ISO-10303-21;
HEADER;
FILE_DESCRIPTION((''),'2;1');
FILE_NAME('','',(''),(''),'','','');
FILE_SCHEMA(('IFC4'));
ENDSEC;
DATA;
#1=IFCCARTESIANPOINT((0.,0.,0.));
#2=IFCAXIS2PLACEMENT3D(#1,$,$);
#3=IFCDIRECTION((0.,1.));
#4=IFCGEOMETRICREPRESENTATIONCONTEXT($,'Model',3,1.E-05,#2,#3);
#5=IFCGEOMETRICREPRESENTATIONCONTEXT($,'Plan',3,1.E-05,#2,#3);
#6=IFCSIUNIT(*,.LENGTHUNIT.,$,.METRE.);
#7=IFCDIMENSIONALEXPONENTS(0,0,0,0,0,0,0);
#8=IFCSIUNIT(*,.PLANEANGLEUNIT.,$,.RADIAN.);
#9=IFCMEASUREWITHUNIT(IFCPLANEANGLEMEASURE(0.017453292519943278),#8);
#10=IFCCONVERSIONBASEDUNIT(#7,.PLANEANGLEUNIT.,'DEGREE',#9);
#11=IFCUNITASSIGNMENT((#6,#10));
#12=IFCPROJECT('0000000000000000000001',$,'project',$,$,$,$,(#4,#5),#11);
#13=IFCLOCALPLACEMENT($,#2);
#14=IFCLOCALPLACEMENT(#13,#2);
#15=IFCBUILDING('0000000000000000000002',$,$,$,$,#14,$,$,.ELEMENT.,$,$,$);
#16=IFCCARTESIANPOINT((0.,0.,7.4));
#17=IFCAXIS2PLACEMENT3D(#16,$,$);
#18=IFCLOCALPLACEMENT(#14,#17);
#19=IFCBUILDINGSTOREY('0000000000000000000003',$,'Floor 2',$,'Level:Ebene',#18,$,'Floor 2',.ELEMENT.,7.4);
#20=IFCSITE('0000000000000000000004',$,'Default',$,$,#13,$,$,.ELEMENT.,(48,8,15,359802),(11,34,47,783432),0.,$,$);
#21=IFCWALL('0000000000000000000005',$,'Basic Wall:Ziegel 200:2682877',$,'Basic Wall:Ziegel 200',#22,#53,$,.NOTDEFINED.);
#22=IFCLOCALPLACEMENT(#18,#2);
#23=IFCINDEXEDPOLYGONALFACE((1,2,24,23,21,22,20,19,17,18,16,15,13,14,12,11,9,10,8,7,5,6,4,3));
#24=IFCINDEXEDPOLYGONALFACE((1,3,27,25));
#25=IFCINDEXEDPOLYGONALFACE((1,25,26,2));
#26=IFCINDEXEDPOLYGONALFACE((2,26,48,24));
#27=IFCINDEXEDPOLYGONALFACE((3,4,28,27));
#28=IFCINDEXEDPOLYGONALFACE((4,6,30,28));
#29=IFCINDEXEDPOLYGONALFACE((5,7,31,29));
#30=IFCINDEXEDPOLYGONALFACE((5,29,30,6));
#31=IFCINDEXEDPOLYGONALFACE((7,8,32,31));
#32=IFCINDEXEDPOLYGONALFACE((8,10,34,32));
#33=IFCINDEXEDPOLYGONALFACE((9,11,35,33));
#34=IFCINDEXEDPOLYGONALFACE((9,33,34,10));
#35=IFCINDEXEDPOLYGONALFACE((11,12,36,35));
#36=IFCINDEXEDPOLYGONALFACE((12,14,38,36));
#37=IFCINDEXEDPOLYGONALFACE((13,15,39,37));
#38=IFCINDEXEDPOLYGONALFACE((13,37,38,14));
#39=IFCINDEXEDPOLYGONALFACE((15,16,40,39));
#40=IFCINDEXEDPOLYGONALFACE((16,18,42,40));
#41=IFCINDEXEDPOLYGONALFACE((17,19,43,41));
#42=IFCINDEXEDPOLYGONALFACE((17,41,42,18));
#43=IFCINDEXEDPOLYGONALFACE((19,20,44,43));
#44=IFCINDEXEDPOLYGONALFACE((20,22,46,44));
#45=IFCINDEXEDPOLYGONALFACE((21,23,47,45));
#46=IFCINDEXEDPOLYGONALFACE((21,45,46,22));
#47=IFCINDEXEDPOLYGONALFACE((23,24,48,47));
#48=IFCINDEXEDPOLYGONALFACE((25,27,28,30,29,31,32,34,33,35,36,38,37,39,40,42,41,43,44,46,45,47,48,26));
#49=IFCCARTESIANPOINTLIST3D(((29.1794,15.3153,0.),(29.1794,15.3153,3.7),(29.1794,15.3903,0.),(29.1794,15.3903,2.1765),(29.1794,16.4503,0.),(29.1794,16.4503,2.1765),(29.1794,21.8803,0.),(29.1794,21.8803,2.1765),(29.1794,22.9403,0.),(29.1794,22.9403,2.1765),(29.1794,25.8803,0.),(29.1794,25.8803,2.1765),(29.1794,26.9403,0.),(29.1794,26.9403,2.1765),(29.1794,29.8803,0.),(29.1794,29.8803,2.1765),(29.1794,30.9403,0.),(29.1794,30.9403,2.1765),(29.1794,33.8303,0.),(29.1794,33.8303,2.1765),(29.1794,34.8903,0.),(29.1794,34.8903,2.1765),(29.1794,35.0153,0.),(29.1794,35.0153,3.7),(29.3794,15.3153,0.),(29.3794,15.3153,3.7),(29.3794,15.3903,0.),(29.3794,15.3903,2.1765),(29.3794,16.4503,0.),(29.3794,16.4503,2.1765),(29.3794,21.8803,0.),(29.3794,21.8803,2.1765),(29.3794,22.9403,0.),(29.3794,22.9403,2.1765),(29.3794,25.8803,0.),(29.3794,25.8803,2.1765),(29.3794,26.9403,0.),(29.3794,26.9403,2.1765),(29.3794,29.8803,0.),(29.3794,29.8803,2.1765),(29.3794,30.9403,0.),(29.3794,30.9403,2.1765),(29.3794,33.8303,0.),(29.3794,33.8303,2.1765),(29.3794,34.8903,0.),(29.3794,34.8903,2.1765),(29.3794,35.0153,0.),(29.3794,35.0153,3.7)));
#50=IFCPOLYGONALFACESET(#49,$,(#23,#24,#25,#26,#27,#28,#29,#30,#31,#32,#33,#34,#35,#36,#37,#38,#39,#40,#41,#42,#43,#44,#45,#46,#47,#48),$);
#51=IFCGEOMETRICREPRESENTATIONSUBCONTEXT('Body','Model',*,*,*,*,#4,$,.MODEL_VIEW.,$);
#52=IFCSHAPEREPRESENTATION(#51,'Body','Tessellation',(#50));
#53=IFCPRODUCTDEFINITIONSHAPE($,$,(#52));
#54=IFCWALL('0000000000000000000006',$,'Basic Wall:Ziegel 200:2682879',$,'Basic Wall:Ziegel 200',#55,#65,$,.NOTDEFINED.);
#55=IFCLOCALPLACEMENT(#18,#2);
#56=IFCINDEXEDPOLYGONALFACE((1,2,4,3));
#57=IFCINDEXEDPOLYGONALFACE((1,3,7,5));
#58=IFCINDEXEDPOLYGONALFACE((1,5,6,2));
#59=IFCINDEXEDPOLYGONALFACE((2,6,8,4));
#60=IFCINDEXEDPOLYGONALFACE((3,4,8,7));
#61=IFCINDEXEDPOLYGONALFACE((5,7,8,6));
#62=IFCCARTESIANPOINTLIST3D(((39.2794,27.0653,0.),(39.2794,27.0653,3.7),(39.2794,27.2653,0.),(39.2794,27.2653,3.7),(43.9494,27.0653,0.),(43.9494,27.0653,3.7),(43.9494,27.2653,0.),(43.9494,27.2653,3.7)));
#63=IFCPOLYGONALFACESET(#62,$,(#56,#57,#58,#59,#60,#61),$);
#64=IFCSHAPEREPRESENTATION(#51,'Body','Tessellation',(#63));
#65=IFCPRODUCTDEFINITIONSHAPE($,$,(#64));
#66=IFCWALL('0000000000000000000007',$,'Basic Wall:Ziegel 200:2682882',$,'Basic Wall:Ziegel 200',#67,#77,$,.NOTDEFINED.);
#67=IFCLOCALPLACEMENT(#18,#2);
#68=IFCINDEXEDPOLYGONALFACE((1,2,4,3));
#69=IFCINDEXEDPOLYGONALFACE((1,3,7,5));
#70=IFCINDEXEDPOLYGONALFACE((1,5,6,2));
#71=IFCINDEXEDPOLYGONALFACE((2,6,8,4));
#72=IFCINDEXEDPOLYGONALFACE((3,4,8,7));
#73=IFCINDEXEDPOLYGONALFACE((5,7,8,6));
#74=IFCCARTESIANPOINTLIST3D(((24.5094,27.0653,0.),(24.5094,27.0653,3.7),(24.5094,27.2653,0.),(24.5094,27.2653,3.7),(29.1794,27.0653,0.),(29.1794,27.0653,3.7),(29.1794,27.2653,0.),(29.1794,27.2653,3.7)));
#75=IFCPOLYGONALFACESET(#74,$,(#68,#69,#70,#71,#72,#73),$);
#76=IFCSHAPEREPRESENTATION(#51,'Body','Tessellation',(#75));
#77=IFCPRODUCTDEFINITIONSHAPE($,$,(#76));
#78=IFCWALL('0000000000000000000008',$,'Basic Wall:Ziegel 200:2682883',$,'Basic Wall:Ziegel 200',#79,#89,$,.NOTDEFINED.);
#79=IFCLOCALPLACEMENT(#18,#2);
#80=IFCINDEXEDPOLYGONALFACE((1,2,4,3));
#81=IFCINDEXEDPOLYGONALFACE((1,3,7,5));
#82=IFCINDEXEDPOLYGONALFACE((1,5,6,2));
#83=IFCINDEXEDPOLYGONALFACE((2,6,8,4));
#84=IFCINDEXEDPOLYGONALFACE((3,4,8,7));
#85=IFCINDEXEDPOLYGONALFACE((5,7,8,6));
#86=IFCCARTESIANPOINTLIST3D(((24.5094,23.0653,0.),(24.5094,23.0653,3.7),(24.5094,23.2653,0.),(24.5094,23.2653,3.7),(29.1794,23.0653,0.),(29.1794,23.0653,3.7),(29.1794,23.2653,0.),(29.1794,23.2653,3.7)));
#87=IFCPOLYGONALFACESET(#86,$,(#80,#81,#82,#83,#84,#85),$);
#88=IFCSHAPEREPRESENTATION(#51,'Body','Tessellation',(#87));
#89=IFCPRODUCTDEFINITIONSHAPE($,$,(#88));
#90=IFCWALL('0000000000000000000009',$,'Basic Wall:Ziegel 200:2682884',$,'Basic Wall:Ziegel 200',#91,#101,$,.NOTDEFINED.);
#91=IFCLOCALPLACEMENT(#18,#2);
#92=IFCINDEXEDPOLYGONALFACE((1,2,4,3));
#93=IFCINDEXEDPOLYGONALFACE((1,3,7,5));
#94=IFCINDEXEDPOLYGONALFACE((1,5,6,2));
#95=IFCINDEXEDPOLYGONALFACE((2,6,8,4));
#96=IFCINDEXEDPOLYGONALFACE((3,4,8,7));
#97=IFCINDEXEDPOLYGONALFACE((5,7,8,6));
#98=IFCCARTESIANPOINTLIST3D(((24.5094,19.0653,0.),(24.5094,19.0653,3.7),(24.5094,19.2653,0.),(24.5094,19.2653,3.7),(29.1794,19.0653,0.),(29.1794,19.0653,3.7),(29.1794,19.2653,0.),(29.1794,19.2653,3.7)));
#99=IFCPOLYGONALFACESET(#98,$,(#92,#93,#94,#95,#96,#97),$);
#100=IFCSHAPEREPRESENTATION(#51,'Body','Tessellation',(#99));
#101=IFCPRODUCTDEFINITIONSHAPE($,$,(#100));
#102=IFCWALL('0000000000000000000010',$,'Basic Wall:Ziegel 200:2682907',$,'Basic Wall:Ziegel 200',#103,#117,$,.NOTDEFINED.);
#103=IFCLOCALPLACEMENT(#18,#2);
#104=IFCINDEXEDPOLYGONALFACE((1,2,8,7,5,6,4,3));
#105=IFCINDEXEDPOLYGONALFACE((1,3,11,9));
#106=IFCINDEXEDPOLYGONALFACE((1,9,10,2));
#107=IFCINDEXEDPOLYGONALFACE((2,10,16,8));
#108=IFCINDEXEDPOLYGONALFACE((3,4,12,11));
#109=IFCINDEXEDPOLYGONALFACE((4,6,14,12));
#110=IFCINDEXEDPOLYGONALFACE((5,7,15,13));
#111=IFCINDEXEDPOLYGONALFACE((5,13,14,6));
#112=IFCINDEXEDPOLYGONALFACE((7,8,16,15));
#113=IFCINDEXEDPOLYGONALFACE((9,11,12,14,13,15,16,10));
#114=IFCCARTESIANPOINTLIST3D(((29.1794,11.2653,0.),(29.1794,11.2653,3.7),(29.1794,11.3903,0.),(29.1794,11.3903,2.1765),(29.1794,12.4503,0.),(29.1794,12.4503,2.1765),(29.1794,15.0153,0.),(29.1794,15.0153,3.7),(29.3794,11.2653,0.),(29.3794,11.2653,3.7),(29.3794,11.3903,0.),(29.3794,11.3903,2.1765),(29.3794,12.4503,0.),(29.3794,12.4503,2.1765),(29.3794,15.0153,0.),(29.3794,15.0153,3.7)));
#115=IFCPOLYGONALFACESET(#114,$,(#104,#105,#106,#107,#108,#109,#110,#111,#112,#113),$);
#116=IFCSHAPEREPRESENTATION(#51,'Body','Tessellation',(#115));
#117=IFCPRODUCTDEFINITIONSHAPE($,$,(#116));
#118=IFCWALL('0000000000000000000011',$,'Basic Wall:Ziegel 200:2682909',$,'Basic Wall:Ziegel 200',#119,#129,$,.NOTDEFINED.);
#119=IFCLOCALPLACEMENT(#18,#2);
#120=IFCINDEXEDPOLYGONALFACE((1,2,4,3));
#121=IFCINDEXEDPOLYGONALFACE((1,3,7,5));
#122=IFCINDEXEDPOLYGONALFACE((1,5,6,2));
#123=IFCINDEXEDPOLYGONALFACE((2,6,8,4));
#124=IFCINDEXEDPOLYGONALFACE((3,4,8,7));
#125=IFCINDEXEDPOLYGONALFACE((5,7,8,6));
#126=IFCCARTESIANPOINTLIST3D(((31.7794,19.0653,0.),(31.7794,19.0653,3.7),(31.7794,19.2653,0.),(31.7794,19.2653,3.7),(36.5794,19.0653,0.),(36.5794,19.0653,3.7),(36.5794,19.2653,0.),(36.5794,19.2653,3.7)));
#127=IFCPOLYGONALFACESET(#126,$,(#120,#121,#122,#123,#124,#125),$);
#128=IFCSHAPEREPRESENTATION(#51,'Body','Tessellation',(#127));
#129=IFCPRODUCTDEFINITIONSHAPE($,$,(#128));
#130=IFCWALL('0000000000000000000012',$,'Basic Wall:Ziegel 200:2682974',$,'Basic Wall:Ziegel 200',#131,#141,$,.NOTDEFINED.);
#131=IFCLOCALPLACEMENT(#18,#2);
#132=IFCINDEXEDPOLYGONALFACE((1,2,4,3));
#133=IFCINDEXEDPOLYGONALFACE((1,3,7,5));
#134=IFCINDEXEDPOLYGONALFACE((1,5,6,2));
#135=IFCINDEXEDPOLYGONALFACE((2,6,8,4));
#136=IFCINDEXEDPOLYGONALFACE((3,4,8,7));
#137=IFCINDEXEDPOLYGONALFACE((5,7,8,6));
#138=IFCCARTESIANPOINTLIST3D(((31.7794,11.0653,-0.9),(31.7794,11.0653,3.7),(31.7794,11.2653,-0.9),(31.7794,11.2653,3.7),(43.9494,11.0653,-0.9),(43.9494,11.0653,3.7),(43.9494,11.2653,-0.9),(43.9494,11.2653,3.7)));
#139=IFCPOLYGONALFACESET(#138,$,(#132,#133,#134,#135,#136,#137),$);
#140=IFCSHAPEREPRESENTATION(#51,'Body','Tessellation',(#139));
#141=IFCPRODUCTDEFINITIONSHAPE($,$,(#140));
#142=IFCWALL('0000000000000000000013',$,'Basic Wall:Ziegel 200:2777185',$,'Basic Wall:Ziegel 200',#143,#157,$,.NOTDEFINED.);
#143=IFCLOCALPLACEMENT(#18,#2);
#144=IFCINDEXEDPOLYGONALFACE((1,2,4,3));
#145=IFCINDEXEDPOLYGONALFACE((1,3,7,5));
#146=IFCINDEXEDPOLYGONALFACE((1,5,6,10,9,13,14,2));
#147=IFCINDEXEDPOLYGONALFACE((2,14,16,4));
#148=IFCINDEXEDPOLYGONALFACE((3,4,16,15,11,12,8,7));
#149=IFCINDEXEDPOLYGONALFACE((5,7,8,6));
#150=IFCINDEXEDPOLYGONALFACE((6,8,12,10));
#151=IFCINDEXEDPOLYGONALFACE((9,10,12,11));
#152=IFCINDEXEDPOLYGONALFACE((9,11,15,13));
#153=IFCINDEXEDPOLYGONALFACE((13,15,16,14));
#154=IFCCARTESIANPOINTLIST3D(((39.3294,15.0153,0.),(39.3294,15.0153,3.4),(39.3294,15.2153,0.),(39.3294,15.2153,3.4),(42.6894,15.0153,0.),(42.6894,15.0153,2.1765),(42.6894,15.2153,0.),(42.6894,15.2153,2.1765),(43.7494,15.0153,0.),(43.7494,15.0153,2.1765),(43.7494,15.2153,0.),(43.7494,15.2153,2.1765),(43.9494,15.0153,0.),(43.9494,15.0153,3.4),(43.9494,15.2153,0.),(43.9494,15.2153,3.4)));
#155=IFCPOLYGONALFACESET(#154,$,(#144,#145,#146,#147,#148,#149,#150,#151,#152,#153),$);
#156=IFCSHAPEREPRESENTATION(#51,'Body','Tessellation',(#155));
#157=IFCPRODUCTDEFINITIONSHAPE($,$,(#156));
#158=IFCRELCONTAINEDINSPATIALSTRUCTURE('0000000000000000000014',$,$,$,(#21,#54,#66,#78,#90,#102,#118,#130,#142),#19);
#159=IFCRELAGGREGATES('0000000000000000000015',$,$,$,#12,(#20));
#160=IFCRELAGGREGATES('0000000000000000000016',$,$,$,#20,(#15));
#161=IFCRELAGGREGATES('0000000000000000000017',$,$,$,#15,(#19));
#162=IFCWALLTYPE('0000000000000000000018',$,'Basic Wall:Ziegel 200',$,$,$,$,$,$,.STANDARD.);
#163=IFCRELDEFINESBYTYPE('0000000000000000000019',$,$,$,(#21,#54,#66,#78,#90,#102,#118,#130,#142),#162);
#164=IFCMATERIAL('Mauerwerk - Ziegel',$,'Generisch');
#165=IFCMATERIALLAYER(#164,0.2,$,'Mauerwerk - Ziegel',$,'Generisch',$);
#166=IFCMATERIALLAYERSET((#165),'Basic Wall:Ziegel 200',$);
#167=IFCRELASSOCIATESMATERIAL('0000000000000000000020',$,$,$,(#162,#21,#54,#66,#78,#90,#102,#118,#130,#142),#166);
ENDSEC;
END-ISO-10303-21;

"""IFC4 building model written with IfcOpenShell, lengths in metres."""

from ifc_helpers import new_model, entity, si_unit, converted_unit, direction, frame, frame_2d, origin, place, context, subcontext, project, spatial, polyline, rectangle, extrude, clip, bounded_halfspace, material, layer, layer_set, layer_usage, type_object, element, save


model = new_model("IFC4")

# Units and contexts
model_context = context("Model", 3, precision=1e-05, world=origin(), true_north=direction((0.0, 1.0)))
plan_context = context("Plan", 3, precision=1e-05, world=origin(), true_north=direction((0.0, 1.0)))
body_context = subcontext(model_context, "Body", "Model", "MODEL_VIEW")
ifc_project = project(units=[si_unit("LENGTHUNIT", "METRE"), converted_unit("PLANEANGLEUNIT", "DEGREE", entity("IfcPlaneAngleMeasure", 0.017453292519943278), si_unit("PLANEANGLEUNIT", "RADIAN"), dimensions=[0, 0, 0, 0, 0, 0, 0])], contexts=[model_context, plan_context])

# Site, building, storey
site_placement = place(None, origin())
site = spatial("IfcSite", under=ifc_project, at=site_placement, Name="Default", CompositionType="ELEMENT", RefLatitude=(48, 8, 15, 359802), RefLongitude=(11, 34, 47, 783432), RefElevation=0.0)
building_placement = place(site_placement, origin())
building = spatial("IfcBuilding", under=site, at=building_placement, CompositionType="ELEMENT")
storey_placement = place(building_placement, frame((0.0, 0.0, 7.4)))
storey = spatial("IfcBuildingStorey", under=building, at=storey_placement, Name="Floor 2", ObjectType="Level:Ebene", LongName="Floor 2", CompositionType="ELEMENT", Elevation=7.4)

# Shared definitions
ifc_material_1 = material(Name="Mauerwerk - Ziegel", Category="Generisch")
ifc_layer_1 = layer(ifc_material_1, 0.2, Name="Mauerwerk - Ziegel", Category="Generisch")
ifc_layer_set_1 = layer_set([ifc_layer_1], Name="Basic Wall:Ziegel 200")
ifc_layer_usage_1 = layer_usage(ifc_layer_set_1, "AXIS2", "NEGATIVE", 0.1)
wall_type_1 = type_object("IfcWallType", Name="Basic Wall:Ziegel 200", PredefinedType="STANDARD", material=ifc_layer_set_1)

# Wall, openings
wall_1_placement = place(storey_placement, frame((29.2794, 15.3153, 0.0), z_axis=(0.0, 0.0, 1.0), x_axis=(0.0, 1.0, 0.0)))
wall_1 = element("IfcWall", 1, at=wall_1_placement, inside=storey, type_object=wall_type_1, material=ifc_layer_usage_1, Name="Basic Wall:Ziegel 200:2682877", ObjectType="Basic Wall:Ziegel 200", PredefinedType="NOTDEFINED", context=body_context, shape_type="SweptSolid", body=[
    extrude(rectangle(XDim=19.7, YDim=0.2, at=frame_2d((9.85, 0.0), x_axis=(1.0, 0.0))), origin(), (0.0, 0.0, 1.0), 3.7),
])
opening_1_placement = place(wall_1_placement, frame((15.625, 0.1, 0.0)))
element("IfcOpeningElement", 2, at=opening_1_placement, cuts=wall_1, PredefinedType="OPENING", context=body_context, shape_type="SweptSolid", body=[
    extrude(rectangle(XDim=2.1765, YDim=1.06, at=frame_2d((1.0882, 0.53), x_axis=(1.0, 0.0))), frame((0.0, 0.0, 0.0), z_axis=(0.0, -1.0, 0.0), x_axis=(0.0, 0.0, 1.0)), (0.0, 0.0, 1.0), 0.2),
])
opening_2_placement = place(wall_1_placement, frame((11.625, 0.1, 0.0)))
element("IfcOpeningElement", 3, at=opening_2_placement, cuts=wall_1, PredefinedType="OPENING", context=body_context, shape_type="SweptSolid", body=[
    extrude(rectangle(XDim=2.1765, YDim=1.06, at=frame_2d((1.0882, 0.53), x_axis=(1.0, 0.0))), frame((0.0, 0.0, 0.0), z_axis=(0.0, -1.0, 0.0), x_axis=(0.0, 0.0, 1.0)), (0.0, 0.0, 1.0), 0.2),
])
opening_3_placement = place(wall_1_placement, frame((7.625, 0.1, 0.0)))
element("IfcOpeningElement", 4, at=opening_3_placement, cuts=wall_1, PredefinedType="OPENING", context=body_context, shape_type="SweptSolid", body=[
    extrude(rectangle(XDim=2.1765, YDim=1.06, at=frame_2d((1.0882, 0.53), x_axis=(1.0, 0.0))), frame((0.0, 0.0, 0.0), z_axis=(0.0, -1.0, 0.0), x_axis=(0.0, 0.0, 1.0)), (0.0, 0.0, 1.0), 0.2),
])
opening_4_placement = place(wall_1_placement, frame((1.135, 0.1, 0.0)))
element("IfcOpeningElement", 5, at=opening_4_placement, cuts=wall_1, PredefinedType="OPENING", context=body_context, shape_type="SweptSolid", body=[
    extrude(rectangle(XDim=2.1765, YDim=1.06, at=frame_2d((1.0882, 0.53), x_axis=(1.0, 0.0))), frame((0.0, 0.0, 0.0), z_axis=(0.0, -1.0, 0.0), x_axis=(0.0, 0.0, 1.0)), (0.0, 0.0, 1.0), 0.2),
])
opening_5_placement = place(wall_1_placement, frame((19.575, 0.1, 0.0)))
element("IfcOpeningElement", 6, at=opening_5_placement, cuts=wall_1, PredefinedType="OPENING", context=body_context, shape_type="SweptSolid", body=[
    extrude(rectangle(XDim=2.1765, YDim=1.06, at=frame_2d((1.0882, 0.53), x_axis=(1.0, 0.0))), frame((0.0, 0.0, 0.0), z_axis=(0.0, -1.0, 0.0), x_axis=(0.0, 0.0, 1.0)), (0.0, 0.0, 1.0), 0.2),
])

# Walls
wall_2_placement = place(storey_placement, frame((39.2794, 27.1653, 0.0)))
element("IfcWall", 7, at=wall_2_placement, inside=storey, type_object=wall_type_1, material=ifc_layer_usage_1, Name="Basic Wall:Ziegel 200:2682879", ObjectType="Basic Wall:Ziegel 200", PredefinedType="NOTDEFINED", context=body_context, shape_type="SweptSolid", body=[
    extrude(rectangle(XDim=4.67, YDim=0.2, at=frame_2d((2.335, 0.0), x_axis=(-1.0, 0.0))), origin(), (0.0, 0.0, 1.0), 3.7),
])
wall_3_placement = place(storey_placement, frame((29.1794, 27.1653, 0.0), z_axis=(0.0, 0.0, 1.0), x_axis=(-1.0, 0.0, 0.0)))
element("IfcWall", 8, at=wall_3_placement, inside=storey, type_object=wall_type_1, material=ifc_layer_usage_1, Name="Basic Wall:Ziegel 200:2682882", ObjectType="Basic Wall:Ziegel 200", PredefinedType="NOTDEFINED", context=body_context, shape_type="SweptSolid", body=[
    extrude(rectangle(XDim=4.67, YDim=0.2, at=frame_2d((2.335, 0.0), x_axis=(-1.0, 0.0))), origin(), (0.0, 0.0, 1.0), 3.7),
])
wall_4_placement = place(storey_placement, frame((29.1794, 23.1653, 0.0), z_axis=(0.0, 0.0, 1.0), x_axis=(-1.0, 0.0, 0.0)))
element("IfcWall", 9, at=wall_4_placement, inside=storey, type_object=wall_type_1, material=ifc_layer_usage_1, Name="Basic Wall:Ziegel 200:2682883", ObjectType="Basic Wall:Ziegel 200", PredefinedType="NOTDEFINED", context=body_context, shape_type="SweptSolid", body=[
    extrude(rectangle(XDim=4.67, YDim=0.2, at=frame_2d((2.335, 0.0), x_axis=(-1.0, 0.0))), origin(), (0.0, 0.0, 1.0), 3.7),
])
wall_5_placement = place(storey_placement, frame((29.1794, 19.1653, 0.0), z_axis=(0.0, 0.0, 1.0), x_axis=(-1.0, 0.0, 0.0)))
element("IfcWall", 10, at=wall_5_placement, inside=storey, type_object=wall_type_1, material=ifc_layer_usage_1, Name="Basic Wall:Ziegel 200:2682884", ObjectType="Basic Wall:Ziegel 200", PredefinedType="NOTDEFINED", context=body_context, shape_type="SweptSolid", body=[
    extrude(rectangle(XDim=4.67, YDim=0.2, at=frame_2d((2.335, 0.0), x_axis=(-1.0, 0.0))), origin(), (0.0, 0.0, 1.0), 3.7),
])

# Wall, opening
wall_6_placement = place(storey_placement, frame((29.2794, 15.0153, 0.0), z_axis=(0.0, 0.0, 1.0), x_axis=(0.0, -1.0, 0.0)))
wall_6 = element("IfcWall", 11, at=wall_6_placement, inside=storey, type_object=wall_type_1, material=ifc_layer_usage_1, Name="Basic Wall:Ziegel 200:2682907", ObjectType="Basic Wall:Ziegel 200", PredefinedType="NOTDEFINED", context=body_context, shape_type="SweptSolid", body=[
    extrude(rectangle(XDim=3.75, YDim=0.2, at=frame_2d((1.875, 0.0), x_axis=(-1.0, 0.0))), origin(), (0.0, 0.0, 1.0), 3.7),
])
opening_6_placement = place(wall_6_placement, frame((2.565, -0.1, 0.0)))
element("IfcOpeningElement", 12, at=opening_6_placement, cuts=wall_6, PredefinedType="OPENING", context=body_context, shape_type="SweptSolid", body=[
    extrude(rectangle(XDim=2.1765, YDim=1.06, at=frame_2d((1.0882, 0.53), x_axis=(1.0, 0.0))), frame((0.0, 0.0, 0.0), z_axis=(0.0, 1.0, 0.0), x_axis=(0.0, 0.0, 1.0)), (0.0, 0.0, 1.0), 0.2),
])

# Walls
wall_7_placement = place(storey_placement, frame((31.7794, 19.1653, 0.0)))
element("IfcWall", 13, at=wall_7_placement, inside=storey, type_object=wall_type_1, material=ifc_layer_usage_1, Name="Basic Wall:Ziegel 200:2682909", ObjectType="Basic Wall:Ziegel 200", PredefinedType="NOTDEFINED", context=body_context, shape_type="SweptSolid", body=[
    extrude(rectangle(XDim=4.8, YDim=0.2, at=frame_2d((2.4, 0.0), x_axis=(-1.0, 0.0))), origin(), (0.0, 0.0, 1.0), 3.7),
])
wall_8_placement = place(storey_placement, frame((43.9494, 11.1653, -0.9), z_axis=(0.0, 0.0, 1.0), x_axis=(-1.0, 0.0, 0.0)))
element("IfcWall", 14, at=wall_8_placement, inside=storey, type_object=wall_type_1, material=ifc_layer_usage_1, Name="Basic Wall:Ziegel 200:2682974", ObjectType="Basic Wall:Ziegel 200", PredefinedType="NOTDEFINED", context=body_context, shape_type="SweptSolid", body=[
    extrude(rectangle(XDim=12.17, YDim=0.2, at=frame_2d((6.085, 0.0), x_axis=(-1.0, 0.0))), origin(), (0.0, 0.0, 1.0), 4.6),
])

# Wall, opening
ifc_layer_usage_2 = layer_usage(ifc_layer_set_1, "AXIS2", "POSITIVE", -0.1)
wall_9_placement = place(storey_placement, frame((39.3294, 15.1153, 0.0)))
wall_9 = element("IfcWall", 15, at=wall_9_placement, inside=storey, type_object=wall_type_1, material=ifc_layer_usage_2, Name="Basic Wall:Ziegel 200:2777185", ObjectType="Basic Wall:Ziegel 200", PredefinedType="NOTDEFINED", context=body_context, shape_type="Clipping", body=[
    clip(extrude(rectangle(XDim=4.62, YDim=0.2, at=frame_2d((2.31, 0.0), x_axis=(-1.0, 0.0))), origin(), (0.0, 0.0, 1.0), 3.4), bounded_halfspace(frame((0.0, -0.1, 3.4), z_axis=(0.0, 0.0, -1.0), x_axis=(-1.0, 0.0, 0.0)), True, frame((0.0, -0.1, 3.4)), polyline([(0.0, 0.0), (4.62, 0.0), (4.62, 0.2), (0.0, 0.2), (0.0, 0.0)]))),
])
opening_7_placement = place(wall_9_placement, frame((4.42, 0.1, 0.0)))
element("IfcOpeningElement", 16, at=opening_7_placement, cuts=wall_9, PredefinedType="OPENING", context=body_context, shape_type="SweptSolid", body=[
    extrude(rectangle(XDim=2.1765, YDim=1.06, at=frame_2d((1.0882, 0.53), x_axis=(1.0, 0.0))), frame((0.0, 0.0, 0.0), z_axis=(0.0, -1.0, 0.0), x_axis=(0.0, 0.0, 1.0)), (0.0, 0.0, 1.0), 0.2),
])

save(model, "model.ifc")
